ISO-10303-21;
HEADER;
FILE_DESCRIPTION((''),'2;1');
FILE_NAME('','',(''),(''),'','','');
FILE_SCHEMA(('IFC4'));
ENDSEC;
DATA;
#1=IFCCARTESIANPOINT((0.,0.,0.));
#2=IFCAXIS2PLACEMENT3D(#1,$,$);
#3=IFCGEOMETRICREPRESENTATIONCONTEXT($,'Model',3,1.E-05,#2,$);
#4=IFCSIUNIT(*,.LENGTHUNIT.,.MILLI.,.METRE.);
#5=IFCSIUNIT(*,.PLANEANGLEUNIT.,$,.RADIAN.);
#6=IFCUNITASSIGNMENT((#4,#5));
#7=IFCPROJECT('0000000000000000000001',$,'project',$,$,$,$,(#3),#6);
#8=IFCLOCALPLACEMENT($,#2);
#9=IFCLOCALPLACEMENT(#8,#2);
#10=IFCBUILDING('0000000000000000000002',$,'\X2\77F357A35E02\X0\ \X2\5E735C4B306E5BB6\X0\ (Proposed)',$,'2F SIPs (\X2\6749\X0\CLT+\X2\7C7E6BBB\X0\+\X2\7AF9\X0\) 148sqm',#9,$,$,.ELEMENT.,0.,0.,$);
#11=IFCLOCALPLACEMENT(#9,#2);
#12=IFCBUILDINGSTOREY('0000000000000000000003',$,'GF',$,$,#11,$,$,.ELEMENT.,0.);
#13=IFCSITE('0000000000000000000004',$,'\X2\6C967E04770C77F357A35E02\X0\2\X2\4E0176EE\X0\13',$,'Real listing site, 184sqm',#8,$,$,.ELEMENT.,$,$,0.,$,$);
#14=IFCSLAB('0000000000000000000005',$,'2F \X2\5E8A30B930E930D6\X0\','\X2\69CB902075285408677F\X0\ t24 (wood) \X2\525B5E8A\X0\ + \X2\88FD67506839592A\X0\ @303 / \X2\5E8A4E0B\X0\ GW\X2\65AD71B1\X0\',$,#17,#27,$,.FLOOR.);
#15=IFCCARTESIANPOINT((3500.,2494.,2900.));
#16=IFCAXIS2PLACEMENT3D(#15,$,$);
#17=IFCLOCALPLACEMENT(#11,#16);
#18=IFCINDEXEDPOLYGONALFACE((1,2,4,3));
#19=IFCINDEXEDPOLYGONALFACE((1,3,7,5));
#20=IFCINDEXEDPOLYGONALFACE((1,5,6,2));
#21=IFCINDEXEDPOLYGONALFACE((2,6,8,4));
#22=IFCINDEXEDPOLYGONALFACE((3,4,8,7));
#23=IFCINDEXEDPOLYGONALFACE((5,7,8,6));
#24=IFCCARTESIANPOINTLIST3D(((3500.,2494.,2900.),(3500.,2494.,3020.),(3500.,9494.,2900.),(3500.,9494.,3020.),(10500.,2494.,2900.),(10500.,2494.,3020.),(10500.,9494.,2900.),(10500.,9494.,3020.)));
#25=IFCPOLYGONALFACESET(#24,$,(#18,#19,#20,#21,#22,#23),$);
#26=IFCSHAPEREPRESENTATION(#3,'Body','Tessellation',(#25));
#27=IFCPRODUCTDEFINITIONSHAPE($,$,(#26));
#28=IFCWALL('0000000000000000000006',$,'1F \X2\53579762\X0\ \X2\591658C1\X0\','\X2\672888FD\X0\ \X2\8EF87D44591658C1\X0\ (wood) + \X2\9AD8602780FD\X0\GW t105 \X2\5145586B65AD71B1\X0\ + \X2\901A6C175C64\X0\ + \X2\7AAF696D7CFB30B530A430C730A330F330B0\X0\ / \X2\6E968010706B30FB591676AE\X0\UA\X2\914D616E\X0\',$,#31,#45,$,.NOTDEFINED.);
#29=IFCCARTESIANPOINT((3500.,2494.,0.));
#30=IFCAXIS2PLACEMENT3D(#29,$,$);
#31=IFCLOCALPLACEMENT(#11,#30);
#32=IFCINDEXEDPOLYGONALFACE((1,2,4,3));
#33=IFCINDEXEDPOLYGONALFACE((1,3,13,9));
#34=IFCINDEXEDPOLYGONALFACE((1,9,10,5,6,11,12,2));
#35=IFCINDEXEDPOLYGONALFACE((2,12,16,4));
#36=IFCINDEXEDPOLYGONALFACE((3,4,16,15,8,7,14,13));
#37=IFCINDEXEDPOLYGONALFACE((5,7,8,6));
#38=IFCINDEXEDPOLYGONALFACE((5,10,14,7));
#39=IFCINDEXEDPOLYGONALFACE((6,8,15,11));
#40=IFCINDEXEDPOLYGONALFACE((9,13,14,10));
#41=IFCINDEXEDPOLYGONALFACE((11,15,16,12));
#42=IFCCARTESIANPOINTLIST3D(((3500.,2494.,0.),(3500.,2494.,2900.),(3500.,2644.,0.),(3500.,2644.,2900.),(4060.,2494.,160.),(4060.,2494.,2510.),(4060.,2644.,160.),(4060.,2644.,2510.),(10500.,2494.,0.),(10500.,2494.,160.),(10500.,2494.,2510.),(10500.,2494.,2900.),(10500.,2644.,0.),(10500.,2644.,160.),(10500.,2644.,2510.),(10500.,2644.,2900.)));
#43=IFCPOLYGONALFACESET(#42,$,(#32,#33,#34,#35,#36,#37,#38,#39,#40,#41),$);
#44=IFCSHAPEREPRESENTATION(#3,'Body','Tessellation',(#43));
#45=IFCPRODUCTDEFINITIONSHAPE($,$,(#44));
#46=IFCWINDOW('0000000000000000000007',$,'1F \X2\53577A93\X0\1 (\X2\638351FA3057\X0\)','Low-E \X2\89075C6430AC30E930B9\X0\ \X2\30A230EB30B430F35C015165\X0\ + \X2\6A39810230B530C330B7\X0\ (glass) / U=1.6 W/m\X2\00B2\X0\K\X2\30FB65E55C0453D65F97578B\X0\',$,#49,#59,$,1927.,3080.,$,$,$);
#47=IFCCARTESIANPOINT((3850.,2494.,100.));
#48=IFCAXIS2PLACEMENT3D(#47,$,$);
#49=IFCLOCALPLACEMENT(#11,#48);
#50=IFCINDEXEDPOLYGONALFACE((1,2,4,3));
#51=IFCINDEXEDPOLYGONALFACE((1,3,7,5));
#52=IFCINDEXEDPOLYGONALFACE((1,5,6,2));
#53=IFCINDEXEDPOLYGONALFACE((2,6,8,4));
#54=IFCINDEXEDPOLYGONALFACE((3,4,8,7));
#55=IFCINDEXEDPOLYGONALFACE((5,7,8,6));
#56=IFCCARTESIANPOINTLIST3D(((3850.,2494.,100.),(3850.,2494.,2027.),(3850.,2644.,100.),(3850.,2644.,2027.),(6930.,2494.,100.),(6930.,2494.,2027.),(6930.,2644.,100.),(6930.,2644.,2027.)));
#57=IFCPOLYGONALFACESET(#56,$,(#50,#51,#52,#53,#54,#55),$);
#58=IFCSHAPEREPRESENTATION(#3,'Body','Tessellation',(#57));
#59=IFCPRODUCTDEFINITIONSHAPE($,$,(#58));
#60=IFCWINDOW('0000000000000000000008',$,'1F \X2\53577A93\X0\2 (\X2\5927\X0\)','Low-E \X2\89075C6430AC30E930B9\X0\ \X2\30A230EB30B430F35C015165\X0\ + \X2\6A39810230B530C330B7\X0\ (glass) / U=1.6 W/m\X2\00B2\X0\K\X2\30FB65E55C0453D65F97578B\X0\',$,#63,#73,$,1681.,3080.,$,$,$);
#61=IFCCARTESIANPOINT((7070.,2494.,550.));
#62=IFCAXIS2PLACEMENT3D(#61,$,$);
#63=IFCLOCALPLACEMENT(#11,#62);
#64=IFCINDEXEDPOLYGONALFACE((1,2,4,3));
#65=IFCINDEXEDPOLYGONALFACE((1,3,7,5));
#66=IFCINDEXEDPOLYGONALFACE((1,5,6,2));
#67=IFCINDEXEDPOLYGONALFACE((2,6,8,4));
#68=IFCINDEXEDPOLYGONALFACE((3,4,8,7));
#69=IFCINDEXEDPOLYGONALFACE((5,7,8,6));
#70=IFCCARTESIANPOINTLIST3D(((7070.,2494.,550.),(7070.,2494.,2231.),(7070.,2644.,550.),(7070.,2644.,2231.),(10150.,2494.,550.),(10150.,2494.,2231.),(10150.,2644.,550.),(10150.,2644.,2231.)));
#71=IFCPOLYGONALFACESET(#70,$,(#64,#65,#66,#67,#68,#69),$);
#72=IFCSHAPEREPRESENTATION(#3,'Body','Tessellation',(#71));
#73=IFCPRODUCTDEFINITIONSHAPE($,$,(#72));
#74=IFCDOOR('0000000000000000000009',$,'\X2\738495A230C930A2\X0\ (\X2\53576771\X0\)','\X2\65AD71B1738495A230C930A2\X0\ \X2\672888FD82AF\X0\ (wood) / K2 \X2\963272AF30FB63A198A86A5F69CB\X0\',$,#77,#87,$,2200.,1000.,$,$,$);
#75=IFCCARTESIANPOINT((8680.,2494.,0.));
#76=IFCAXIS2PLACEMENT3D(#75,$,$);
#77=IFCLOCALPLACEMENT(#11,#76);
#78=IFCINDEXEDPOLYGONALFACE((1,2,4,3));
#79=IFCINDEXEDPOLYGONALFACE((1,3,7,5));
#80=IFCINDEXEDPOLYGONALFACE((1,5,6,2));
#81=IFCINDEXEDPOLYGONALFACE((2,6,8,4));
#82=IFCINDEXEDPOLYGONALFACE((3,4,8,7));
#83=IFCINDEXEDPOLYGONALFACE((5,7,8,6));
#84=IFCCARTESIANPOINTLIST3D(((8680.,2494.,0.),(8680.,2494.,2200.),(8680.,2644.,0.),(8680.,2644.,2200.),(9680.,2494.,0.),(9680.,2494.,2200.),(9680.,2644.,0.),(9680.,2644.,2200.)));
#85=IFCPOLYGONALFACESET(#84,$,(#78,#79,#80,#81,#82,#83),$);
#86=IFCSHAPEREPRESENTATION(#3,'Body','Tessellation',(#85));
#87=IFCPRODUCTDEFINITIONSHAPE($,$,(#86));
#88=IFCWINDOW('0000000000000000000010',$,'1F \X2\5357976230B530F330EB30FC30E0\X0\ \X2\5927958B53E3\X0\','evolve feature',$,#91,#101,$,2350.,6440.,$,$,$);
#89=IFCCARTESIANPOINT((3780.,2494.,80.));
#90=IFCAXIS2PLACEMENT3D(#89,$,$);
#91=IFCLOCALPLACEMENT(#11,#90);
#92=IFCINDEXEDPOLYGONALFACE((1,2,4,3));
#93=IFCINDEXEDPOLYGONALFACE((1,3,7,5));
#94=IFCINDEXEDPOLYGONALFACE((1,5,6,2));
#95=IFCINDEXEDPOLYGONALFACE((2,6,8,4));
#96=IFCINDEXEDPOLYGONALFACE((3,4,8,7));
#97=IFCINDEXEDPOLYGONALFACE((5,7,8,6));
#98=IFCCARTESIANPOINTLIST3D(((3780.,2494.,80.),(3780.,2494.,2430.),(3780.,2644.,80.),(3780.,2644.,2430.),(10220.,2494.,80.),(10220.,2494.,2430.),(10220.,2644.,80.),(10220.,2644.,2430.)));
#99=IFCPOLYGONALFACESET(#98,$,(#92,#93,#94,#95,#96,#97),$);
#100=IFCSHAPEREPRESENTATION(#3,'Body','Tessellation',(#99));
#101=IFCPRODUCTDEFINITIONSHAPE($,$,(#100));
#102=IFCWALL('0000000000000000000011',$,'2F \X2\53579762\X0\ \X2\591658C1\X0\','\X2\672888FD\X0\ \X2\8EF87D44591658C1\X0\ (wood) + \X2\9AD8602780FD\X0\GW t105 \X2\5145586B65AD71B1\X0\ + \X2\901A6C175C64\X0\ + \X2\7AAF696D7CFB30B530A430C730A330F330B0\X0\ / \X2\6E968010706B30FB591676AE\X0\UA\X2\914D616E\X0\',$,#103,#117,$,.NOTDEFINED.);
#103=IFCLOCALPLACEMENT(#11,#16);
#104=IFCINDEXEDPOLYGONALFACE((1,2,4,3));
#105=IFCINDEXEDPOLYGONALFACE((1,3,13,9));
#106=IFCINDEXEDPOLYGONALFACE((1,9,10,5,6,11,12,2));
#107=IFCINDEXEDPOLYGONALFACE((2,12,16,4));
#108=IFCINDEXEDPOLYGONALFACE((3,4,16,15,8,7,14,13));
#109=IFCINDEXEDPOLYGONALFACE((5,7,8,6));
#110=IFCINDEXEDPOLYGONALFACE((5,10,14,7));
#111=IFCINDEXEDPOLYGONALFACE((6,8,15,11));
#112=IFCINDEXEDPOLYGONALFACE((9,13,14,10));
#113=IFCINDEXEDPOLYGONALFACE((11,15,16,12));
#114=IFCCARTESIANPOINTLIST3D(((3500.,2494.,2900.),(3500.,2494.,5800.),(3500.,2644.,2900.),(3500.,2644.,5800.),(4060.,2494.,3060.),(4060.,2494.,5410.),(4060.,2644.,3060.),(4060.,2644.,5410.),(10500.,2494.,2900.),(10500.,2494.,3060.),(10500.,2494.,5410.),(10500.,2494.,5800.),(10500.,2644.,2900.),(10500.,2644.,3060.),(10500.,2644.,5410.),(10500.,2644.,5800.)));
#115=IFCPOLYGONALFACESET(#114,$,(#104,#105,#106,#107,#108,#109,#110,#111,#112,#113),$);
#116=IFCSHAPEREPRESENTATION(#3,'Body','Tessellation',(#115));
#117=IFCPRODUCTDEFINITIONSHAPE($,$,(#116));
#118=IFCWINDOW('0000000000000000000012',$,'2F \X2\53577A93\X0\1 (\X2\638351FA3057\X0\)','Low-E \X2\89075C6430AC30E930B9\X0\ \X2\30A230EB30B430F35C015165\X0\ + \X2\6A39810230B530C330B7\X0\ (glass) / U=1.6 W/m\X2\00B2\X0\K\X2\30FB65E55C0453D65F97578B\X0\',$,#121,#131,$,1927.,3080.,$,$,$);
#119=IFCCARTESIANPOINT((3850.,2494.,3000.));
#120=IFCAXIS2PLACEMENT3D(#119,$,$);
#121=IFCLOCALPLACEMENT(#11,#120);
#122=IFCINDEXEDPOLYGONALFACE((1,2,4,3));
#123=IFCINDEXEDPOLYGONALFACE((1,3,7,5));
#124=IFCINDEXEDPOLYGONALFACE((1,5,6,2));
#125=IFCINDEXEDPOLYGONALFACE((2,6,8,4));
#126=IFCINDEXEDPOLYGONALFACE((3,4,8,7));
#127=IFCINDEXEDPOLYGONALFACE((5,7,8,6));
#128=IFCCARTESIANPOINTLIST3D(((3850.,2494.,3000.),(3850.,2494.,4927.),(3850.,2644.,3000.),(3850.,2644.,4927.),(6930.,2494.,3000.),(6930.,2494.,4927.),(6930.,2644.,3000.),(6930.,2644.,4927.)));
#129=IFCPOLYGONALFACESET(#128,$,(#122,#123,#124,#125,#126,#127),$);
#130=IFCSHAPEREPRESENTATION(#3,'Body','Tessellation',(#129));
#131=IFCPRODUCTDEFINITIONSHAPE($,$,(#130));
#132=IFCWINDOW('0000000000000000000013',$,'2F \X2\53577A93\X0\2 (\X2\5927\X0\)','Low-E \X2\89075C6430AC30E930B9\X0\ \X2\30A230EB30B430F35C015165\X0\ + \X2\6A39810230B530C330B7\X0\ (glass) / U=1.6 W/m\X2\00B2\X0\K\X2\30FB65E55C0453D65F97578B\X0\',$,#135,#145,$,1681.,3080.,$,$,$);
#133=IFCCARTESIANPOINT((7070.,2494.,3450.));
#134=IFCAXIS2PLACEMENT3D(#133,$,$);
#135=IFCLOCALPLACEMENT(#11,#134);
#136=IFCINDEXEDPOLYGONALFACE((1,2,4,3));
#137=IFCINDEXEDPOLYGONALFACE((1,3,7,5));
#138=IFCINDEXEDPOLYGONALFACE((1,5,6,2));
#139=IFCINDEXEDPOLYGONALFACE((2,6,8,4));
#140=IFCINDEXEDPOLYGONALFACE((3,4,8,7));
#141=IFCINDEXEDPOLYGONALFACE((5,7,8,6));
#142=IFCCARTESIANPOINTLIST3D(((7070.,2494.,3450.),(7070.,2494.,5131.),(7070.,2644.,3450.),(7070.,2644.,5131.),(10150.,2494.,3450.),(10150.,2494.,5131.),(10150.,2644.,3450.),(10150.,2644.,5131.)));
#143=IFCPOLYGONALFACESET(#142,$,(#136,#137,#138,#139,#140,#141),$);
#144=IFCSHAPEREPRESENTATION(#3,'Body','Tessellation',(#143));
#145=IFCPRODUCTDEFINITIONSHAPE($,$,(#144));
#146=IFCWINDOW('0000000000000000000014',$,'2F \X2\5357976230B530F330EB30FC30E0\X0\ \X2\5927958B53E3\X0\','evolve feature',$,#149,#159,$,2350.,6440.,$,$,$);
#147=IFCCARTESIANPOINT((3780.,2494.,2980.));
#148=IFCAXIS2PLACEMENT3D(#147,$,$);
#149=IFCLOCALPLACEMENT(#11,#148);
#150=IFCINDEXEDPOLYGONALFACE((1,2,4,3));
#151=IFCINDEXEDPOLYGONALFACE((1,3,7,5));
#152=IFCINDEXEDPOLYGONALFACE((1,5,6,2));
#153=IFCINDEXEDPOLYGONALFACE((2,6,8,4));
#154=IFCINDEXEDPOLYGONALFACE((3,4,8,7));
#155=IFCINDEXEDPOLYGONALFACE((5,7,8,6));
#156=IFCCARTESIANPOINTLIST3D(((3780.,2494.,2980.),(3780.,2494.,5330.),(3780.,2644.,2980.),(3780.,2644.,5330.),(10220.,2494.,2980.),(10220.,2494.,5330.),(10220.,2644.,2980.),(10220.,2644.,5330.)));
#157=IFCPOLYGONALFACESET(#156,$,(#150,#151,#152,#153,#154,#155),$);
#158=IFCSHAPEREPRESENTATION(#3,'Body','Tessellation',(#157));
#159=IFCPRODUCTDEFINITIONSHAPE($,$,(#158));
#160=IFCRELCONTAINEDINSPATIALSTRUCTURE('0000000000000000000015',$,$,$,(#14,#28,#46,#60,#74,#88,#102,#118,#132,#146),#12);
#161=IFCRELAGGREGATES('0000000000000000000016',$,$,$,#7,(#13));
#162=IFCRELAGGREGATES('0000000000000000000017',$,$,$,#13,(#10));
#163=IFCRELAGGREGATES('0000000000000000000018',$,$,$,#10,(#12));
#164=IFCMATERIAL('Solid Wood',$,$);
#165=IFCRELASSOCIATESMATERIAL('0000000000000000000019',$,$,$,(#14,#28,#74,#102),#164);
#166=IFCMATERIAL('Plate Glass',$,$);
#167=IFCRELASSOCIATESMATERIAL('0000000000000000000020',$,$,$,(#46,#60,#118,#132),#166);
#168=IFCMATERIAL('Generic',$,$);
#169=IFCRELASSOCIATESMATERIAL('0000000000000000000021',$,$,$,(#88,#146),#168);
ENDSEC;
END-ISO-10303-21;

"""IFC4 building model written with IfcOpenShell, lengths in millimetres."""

from ifc_helpers import new_model, si_unit, frame, frame_2d, origin, place, context, project, spatial, rectangle, extrude, material, element, fill, save


model = new_model("IFC4")

# Units and contexts
model_context = context("Model", 3, precision=1e-05, world=origin())
ifc_project = project(units=[si_unit("LENGTHUNIT", "METRE", prefix="MILLI"), si_unit("PLANEANGLEUNIT", "RADIAN")], contexts=[model_context])

# Site, building, storey
site_placement = place(None, origin())
site = spatial("IfcSite", under=ifc_project, at=site_placement, Name="沖縄県石垣市2丁目13", ObjectType="Real listing site, 184sqm", CompositionType="ELEMENT", RefElevation=0.0)
building_placement = place(site_placement, origin())
building = spatial("IfcBuilding", under=site, at=building_placement, Name="石垣市 平屋の家 (Proposed)", ObjectType="2F SIPs (杉CLT+籾殻+竹) 148sqm", CompositionType="ELEMENT", ElevationOfRefHeight=0.0, ElevationOfTerrain=0.0)
storey_placement = place(building_placement, origin())
storey = spatial("IfcBuildingStorey", under=building, at=storey_placement, Name="GF", CompositionType="ELEMENT", Elevation=0.0)

# Slab
ifc_material_1 = material(Name="Solid Wood")
slab_1_placement = place(storey_placement, frame((3500.0, 2494.0, 2900.0)))
element("IfcSlab", 1, at=slab_1_placement, inside=storey, material=ifc_material_1, Name="2F 床スラブ", Description="構造用合板 t24 (wood) 剛床 + 製材根太 @303 / 床下 GW断熱", PredefinedType="FLOOR", context=model_context, shape_type="SweptSolid", body=[
    extrude(rectangle(XDim=7000.0, YDim=7000.0, at=frame_2d((3500.0, 3500.0))), frame((3500.0, 2494.0, 2900.0)), (0.0, 0.0, 1.0), 120.0),
])

# Wall, openings, windows, door
wall_1_placement = place(storey_placement, frame((3500.0, 2494.0, 0.0)))
wall_1 = element("IfcWall", 2, at=wall_1_placement, inside=storey, material=ifc_material_1, Name="1F 南面 外壁", Description="木製 軸組外壁 (wood) + 高性能GW t105 充填断熱 + 通気層 + 窯業系サイディング / 準耐火・外皮UA配慮", PredefinedType="NOTDEFINED", context=model_context, shape_type="SweptSolid", body=[
    extrude(rectangle(XDim=7000.0, YDim=150.0, at=frame_2d((3500.0, 75.0))), frame((3500.0, 2494.0, 0.0)), (0.0, 0.0, 1.0), 2900.0),
])
opening_1_placement = place(storey_placement, frame((3850.0, 2494.0, 100.0)))
opening_1 = element("IfcOpeningElement", 3, at=opening_1_placement, cuts=wall_1, PredefinedType="NOTDEFINED", context=model_context, shape_type="SweptSolid", body=[
    extrude(rectangle(XDim=3080.0, YDim=150.0, at=frame_2d((1540.0, 75.0))), frame((3850.0, 2494.0, 100.0)), (0.0, 0.0, 1.0), 1927.0),
])
opening_2_placement = place(storey_placement, frame((7070.0, 2494.0, 550.0)))
opening_2 = element("IfcOpeningElement", 4, at=opening_2_placement, cuts=wall_1, PredefinedType="NOTDEFINED", context=model_context, shape_type="SweptSolid", body=[
    extrude(rectangle(XDim=3080.0, YDim=150.0, at=frame_2d((1540.0, 75.0))), frame((7070.0, 2494.0, 550.0)), (0.0, 0.0, 1.0), 1681.0),
])
opening_3_placement = place(storey_placement, frame((8680.0, 2494.0, 0.0)))
opening_3 = element("IfcOpeningElement", 5, at=opening_3_placement, cuts=wall_1, PredefinedType="NOTDEFINED", context=model_context, shape_type="SweptSolid", body=[
    extrude(rectangle(XDim=1000.0, YDim=150.0, at=frame_2d((500.0, 75.0))), frame((8680.0, 2494.0, 0.0)), (0.0, 0.0, 1.0), 2200.0),
])
opening_4_placement = place(storey_placement, frame((3780.0, 2494.0, 80.0)))
opening_4 = element("IfcOpeningElement", 6, at=opening_4_placement, cuts=wall_1, PredefinedType="NOTDEFINED", context=model_context, shape_type="SweptSolid", body=[
    extrude(rectangle(XDim=6440.0, YDim=150.0, at=frame_2d((3220.0, 75.0))), frame((3780.0, 2494.0, 80.0)), (0.0, 0.0, 1.0), 2350.0),
])
ifc_material_2 = material(Name="Plate Glass")
window_1_placement = place(storey_placement, frame((3850.0, 2494.0, 100.0)))
window_1 = element("IfcWindow", 7, at=window_1_placement, inside=storey, material=ifc_material_2, Name="1F 南窓1 (掃出し)", Description="Low-E 複層ガラス アルゴン封入 + 樹脂サッシ (glass) / U=1.6 W/m²K・日射取得型", OverallHeight=1927.0, OverallWidth=3080.0, context=model_context, shape_type="SweptSolid", body=[
    extrude(rectangle(XDim=3080.0, YDim=150.0, at=frame_2d((1540.0, 75.0))), frame((3850.0, 2494.0, 100.0)), (0.0, 0.0, 1.0), 1927.0),
])
fill(opening_1, window_1)
window_2_placement = place(storey_placement, frame((7070.0, 2494.0, 550.0)))
window_2 = element("IfcWindow", 8, at=window_2_placement, inside=storey, material=ifc_material_2, Name="1F 南窓2 (大)", Description="Low-E 複層ガラス アルゴン封入 + 樹脂サッシ (glass) / U=1.6 W/m²K・日射取得型", OverallHeight=1681.0, OverallWidth=3080.0, context=model_context, shape_type="SweptSolid", body=[
    extrude(rectangle(XDim=3080.0, YDim=150.0, at=frame_2d((1540.0, 75.0))), frame((7070.0, 2494.0, 550.0)), (0.0, 0.0, 1.0), 1681.0),
])
fill(opening_2, window_2)
door_placement = place(storey_placement, frame((8680.0, 2494.0, 0.0)))
door = element("IfcDoor", 9, at=door_placement, inside=storey, material=ifc_material_1, Name="玄関ドア (南東)", Description="断熱玄関ドア 木製芯 (wood) / K2 防犯・採風機構", OverallHeight=2200.0, OverallWidth=1000.0, context=model_context, shape_type="SweptSolid", body=[
    extrude(rectangle(XDim=1000.0, YDim=150.0, at=frame_2d((500.0, 75.0))), frame((8680.0, 2494.0, 0.0)), (0.0, 0.0, 1.0), 2200.0),
])
fill(opening_3, door)
ifc_material_3 = material(Name="Generic")
window_3_placement = place(storey_placement, frame((3780.0, 2494.0, 80.0)))
window_3 = element("IfcWindow", 10, at=window_3_placement, inside=storey, material=ifc_material_3, Name="1F 南面サンルーム 大開口", Description="evolve feature", OverallHeight=2350.0, OverallWidth=6440.0, context=model_context, shape_type="SweptSolid", body=[
    extrude(rectangle(XDim=6440.0, YDim=150.0, at=frame_2d((3220.0, 75.0))), frame((3780.0, 2494.0, 80.0)), (0.0, 0.0, 1.0), 2350.0),
])
fill(opening_4, window_3)

# Wall, openings, windows
wall_2_placement = place(storey_placement, frame((3500.0, 2494.0, 2900.0)))
wall_2 = element("IfcWall", 11, at=wall_2_placement, inside=storey, material=ifc_material_1, Name="2F 南面 外壁", Description="木製 軸組外壁 (wood) + 高性能GW t105 充填断熱 + 通気層 + 窯業系サイディング / 準耐火・外皮UA配慮", PredefinedType="NOTDEFINED", context=model_context, shape_type="SweptSolid", body=[
    extrude(rectangle(XDim=7000.0, YDim=150.0, at=frame_2d((3500.0, 75.0))), frame((3500.0, 2494.0, 2900.0)), (0.0, 0.0, 1.0), 2900.0),
])
opening_5_placement = place(storey_placement, frame((3850.0, 2494.0, 3000.0)))
opening_5 = element("IfcOpeningElement", 12, at=opening_5_placement, cuts=wall_2, PredefinedType="NOTDEFINED", context=model_context, shape_type="SweptSolid", body=[
    extrude(rectangle(XDim=3080.0, YDim=150.0, at=frame_2d((1540.0, 75.0))), frame((3850.0, 2494.0, 3000.0)), (0.0, 0.0, 1.0), 1927.0),
])
opening_6_placement = place(storey_placement, frame((7070.0, 2494.0, 3450.0)))
opening_6 = element("IfcOpeningElement", 13, at=opening_6_placement, cuts=wall_2, PredefinedType="NOTDEFINED", context=model_context, shape_type="SweptSolid", body=[
    extrude(rectangle(XDim=3080.0, YDim=150.0, at=frame_2d((1540.0, 75.0))), frame((7070.0, 2494.0, 3450.0)), (0.0, 0.0, 1.0), 1681.0),
])
opening_7_placement = place(storey_placement, frame((3780.0, 2494.0, 2980.0)))
opening_7 = element("IfcOpeningElement", 14, at=opening_7_placement, cuts=wall_2, PredefinedType="NOTDEFINED", context=model_context, shape_type="SweptSolid", body=[
    extrude(rectangle(XDim=6440.0, YDim=150.0, at=frame_2d((3220.0, 75.0))), frame((3780.0, 2494.0, 2980.0)), (0.0, 0.0, 1.0), 2350.0),
])
window_4_placement = place(storey_placement, frame((3850.0, 2494.0, 3000.0)))
window_4 = element("IfcWindow", 15, at=window_4_placement, inside=storey, material=ifc_material_2, Name="2F 南窓1 (掃出し)", Description="Low-E 複層ガラス アルゴン封入 + 樹脂サッシ (glass) / U=1.6 W/m²K・日射取得型", OverallHeight=1927.0, OverallWidth=3080.0, context=model_context, shape_type="SweptSolid", body=[
    extrude(rectangle(XDim=3080.0, YDim=150.0, at=frame_2d((1540.0, 75.0))), frame((3850.0, 2494.0, 3000.0)), (0.0, 0.0, 1.0), 1927.0),
])
fill(opening_5, window_4)
window_5_placement = place(storey_placement, frame((7070.0, 2494.0, 3450.0)))
window_5 = element("IfcWindow", 16, at=window_5_placement, inside=storey, material=ifc_material_2, Name="2F 南窓2 (大)", Description="Low-E 複層ガラス アルゴン封入 + 樹脂サッシ (glass) / U=1.6 W/m²K・日射取得型", OverallHeight=1681.0, OverallWidth=3080.0, context=model_context, shape_type="SweptSolid", body=[
    extrude(rectangle(XDim=3080.0, YDim=150.0, at=frame_2d((1540.0, 75.0))), frame((7070.0, 2494.0, 3450.0)), (0.0, 0.0, 1.0), 1681.0),
])
fill(opening_6, window_5)
window_6_placement = place(storey_placement, frame((3780.0, 2494.0, 2980.0)))
window_6 = element("IfcWindow", 17, at=window_6_placement, inside=storey, material=ifc_material_3, Name="2F 南面サンルーム 大開口", Description="evolve feature", OverallHeight=2350.0, OverallWidth=6440.0, context=model_context, shape_type="SweptSolid", body=[
    extrude(rectangle(XDim=6440.0, YDim=150.0, at=frame_2d((3220.0, 75.0))), frame((3780.0, 2494.0, 2980.0)), (0.0, 0.0, 1.0), 2350.0),
])
fill(opening_7, window_6)

save(model, "model.ifc")
